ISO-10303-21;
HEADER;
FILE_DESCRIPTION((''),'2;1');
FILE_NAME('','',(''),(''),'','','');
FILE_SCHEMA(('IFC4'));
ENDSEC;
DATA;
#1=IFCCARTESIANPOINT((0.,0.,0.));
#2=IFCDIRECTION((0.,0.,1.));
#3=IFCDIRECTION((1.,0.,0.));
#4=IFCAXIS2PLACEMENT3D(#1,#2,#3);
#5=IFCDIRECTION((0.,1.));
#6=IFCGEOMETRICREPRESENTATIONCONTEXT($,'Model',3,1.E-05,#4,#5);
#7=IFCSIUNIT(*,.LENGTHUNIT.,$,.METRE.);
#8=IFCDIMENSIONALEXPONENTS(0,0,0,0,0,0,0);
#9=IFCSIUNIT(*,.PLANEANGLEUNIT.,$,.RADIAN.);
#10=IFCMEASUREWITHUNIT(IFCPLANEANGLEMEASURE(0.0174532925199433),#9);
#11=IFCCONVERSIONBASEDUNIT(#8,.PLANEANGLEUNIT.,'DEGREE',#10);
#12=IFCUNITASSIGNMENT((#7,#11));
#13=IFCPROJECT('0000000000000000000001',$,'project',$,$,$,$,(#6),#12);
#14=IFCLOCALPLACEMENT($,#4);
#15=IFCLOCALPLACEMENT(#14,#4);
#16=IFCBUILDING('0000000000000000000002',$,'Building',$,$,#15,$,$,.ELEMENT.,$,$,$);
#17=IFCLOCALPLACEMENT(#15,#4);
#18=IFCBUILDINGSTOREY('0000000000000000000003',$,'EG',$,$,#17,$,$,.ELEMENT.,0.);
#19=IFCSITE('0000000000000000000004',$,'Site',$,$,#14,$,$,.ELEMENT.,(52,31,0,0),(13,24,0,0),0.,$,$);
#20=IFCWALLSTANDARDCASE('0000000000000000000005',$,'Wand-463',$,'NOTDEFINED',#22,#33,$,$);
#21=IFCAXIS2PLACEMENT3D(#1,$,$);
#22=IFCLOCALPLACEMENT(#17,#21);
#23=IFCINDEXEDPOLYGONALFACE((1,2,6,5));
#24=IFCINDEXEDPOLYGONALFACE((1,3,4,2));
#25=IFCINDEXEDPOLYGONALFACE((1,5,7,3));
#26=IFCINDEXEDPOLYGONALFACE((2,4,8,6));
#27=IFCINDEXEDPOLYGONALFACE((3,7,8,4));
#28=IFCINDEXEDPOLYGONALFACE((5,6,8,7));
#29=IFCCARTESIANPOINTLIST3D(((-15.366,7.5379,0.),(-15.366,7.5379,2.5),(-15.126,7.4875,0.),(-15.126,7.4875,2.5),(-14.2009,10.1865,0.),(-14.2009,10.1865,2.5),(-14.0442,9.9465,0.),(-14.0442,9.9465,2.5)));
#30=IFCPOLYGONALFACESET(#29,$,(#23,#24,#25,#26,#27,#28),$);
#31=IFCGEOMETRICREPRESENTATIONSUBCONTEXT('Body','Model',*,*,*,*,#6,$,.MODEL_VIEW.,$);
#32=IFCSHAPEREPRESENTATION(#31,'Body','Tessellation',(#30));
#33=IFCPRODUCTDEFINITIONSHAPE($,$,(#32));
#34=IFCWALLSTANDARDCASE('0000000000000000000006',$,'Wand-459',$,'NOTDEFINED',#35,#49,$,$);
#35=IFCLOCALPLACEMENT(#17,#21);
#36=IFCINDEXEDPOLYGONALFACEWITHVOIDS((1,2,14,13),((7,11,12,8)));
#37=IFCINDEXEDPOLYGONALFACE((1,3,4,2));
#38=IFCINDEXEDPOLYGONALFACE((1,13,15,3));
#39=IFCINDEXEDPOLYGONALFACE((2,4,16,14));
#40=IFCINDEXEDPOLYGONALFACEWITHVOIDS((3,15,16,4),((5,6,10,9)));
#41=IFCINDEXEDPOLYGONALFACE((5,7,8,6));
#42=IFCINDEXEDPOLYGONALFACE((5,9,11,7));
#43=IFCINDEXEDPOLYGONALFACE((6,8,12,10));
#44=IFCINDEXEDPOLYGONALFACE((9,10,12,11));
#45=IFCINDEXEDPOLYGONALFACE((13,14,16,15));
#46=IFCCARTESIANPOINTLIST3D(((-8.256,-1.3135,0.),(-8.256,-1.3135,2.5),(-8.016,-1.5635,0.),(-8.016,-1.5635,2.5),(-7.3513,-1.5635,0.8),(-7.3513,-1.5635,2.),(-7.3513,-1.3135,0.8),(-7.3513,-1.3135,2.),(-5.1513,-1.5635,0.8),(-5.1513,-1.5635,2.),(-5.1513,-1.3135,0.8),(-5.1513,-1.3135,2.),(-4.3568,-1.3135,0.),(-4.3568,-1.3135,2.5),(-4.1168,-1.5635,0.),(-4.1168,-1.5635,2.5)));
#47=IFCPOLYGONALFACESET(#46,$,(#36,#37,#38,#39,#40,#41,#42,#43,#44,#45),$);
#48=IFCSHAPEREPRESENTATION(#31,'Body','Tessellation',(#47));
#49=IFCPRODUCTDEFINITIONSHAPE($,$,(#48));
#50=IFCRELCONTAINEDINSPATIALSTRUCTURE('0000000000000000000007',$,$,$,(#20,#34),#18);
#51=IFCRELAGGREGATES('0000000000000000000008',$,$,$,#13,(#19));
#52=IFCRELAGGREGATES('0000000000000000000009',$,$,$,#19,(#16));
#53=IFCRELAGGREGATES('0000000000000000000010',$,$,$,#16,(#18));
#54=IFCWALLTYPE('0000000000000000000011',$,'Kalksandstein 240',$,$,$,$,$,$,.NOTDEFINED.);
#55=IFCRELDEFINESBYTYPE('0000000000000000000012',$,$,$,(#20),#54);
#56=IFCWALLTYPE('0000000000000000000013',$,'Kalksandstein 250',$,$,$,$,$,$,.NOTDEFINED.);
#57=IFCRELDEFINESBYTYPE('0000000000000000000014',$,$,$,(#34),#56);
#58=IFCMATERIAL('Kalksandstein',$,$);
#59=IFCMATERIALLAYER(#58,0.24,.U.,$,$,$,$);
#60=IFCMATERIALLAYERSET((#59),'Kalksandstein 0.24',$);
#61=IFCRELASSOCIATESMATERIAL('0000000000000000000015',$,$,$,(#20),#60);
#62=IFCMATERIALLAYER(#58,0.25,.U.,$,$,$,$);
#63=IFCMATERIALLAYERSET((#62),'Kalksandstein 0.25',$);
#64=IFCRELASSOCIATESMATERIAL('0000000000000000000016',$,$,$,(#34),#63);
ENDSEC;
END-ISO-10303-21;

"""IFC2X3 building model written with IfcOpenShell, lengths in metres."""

from ifc_helpers import new_model, entity, si_unit, converted_unit, direction, frame, origin_with_axes, origin_2d_with_axis, place, context, subcontext, project, spatial, polyline, rectangle, outline, extrude, material, layer, layer_set, layer_usage, type_object, element, save


model = new_model("IFC2X3")

# Units and contexts
model_context = context("Model", 3, precision=1e-05, world=origin_with_axes(), true_north=direction((0.0, 1.0)))
body_context = subcontext(model_context, "Body", "Model", "MODEL_VIEW")
ifc_project = project(units=[si_unit("LENGTHUNIT", "METRE"), converted_unit("PLANEANGLEUNIT", "DEGREE", entity("IfcPlaneAngleMeasure", 0.0174532925199433), si_unit("PLANEANGLEUNIT", "RADIAN"), dimensions=[0, 0, 0, 0, 0, 0, 0])], contexts=[model_context])

# Site, building, storey
site_placement = place(None, origin_with_axes())
site = spatial("IfcSite", under=ifc_project, at=site_placement, Name="Site", CompositionType="ELEMENT", RefLatitude=(52, 31, 0, 0), RefLongitude=(13, 24, 0, 0), RefElevation=0.0)
building_placement = place(site_placement, origin_with_axes())
building = spatial("IfcBuilding", under=site, at=building_placement, Name="Building", CompositionType="ELEMENT")
storey_placement = place(building_placement, origin_with_axes())
storey = spatial("IfcBuildingStorey", under=building, at=storey_placement, Name="EG", CompositionType="ELEMENT", Elevation=0.0)

# Shared definitions
ifc_material_1 = material(Name="Kalksandstein")
ifc_layer_1 = layer(ifc_material_1, 0.24, ventilated="UNKNOWN")
ifc_layer_set_1 = layer_set([ifc_layer_1], Name="Kalksandstein 0.24")
wall_type_1 = type_object("IfcWallType", Name="Kalksandstein 240", PredefinedType="NOTDEFINED")

# Wall
ifc_layer_usage_1 = layer_usage(ifc_layer_set_1, "AXIS2", "POSITIVE", 0.0)
wall_1_placement = place(storey_placement, frame((-14.2009, 10.1865, 0.0), z_axis=(0.0, 0.0, 1.0), x_axis=(-0.402674, -0.915343, 0.0)))
element("IfcWallStandardCase", 1, at=wall_1_placement, inside=storey, type_object=wall_type_1, material=ifc_layer_usage_1, Name="Wand-463", ObjectType="NOTDEFINED", context=body_context, shape_type="SweptSolid", body=[
    extrude(outline(polyline([(0.0, 0.0), (2.8935, 0.0), (2.8431, 0.24), (0.1566, 0.24), (0.0, 0.0)])), origin_with_axes(), (0.0, 0.0, 1.0), 2.5),
])

# Wall, opening
ifc_layer_2 = layer(ifc_material_1, 0.25, ventilated="UNKNOWN")
ifc_layer_set_2 = layer_set([ifc_layer_2], Name="Kalksandstein 0.25")
ifc_layer_usage_2 = layer_usage(ifc_layer_set_2, "AXIS2", "POSITIVE", 0.0)
wall_type_2 = type_object("IfcWallType", Name="Kalksandstein 250", PredefinedType="NOTDEFINED")
wall_2_placement = place(storey_placement, frame((-8.016, -1.5635, 0.0), z_axis=(0.0, 0.0, 1.0), x_axis=(1.0, 0.0, 0.0)))
wall_2 = element("IfcWallStandardCase", 2, at=wall_2_placement, inside=storey, type_object=wall_type_2, material=ifc_layer_usage_2, Name="Wand-459", ObjectType="NOTDEFINED", context=body_context, shape_type="SweptSolid", body=[
    extrude(outline(polyline([(0.0, 0.0), (3.8992, 0.0), (3.6592, 0.25), (-0.24, 0.25), (0.0, 0.0)])), origin_with_axes(), (0.0, 0.0, 1.0), 2.5),
])
opening_1_placement = place(wall_2_placement, frame((1.7647, 0.0, 0.8), z_axis=(0.0, 0.0, 1.0), x_axis=(1.0, 0.0, 0.0)))
element("IfcOpeningElement", 3, at=opening_1_placement, cuts=wall_2, context=body_context, shape_type="SweptSolid", body=[
    extrude(rectangle(XDim=2.2, YDim=1.2, at=origin_2d_with_axis()), frame((0.0, 0.25, 0.6), z_axis=(0.0, 1.0, 0.0), x_axis=(1.0, 0.0, 0.0)), (0.0, 0.0, -1.0), 0.75),
])

save(model, "model.ifc")
